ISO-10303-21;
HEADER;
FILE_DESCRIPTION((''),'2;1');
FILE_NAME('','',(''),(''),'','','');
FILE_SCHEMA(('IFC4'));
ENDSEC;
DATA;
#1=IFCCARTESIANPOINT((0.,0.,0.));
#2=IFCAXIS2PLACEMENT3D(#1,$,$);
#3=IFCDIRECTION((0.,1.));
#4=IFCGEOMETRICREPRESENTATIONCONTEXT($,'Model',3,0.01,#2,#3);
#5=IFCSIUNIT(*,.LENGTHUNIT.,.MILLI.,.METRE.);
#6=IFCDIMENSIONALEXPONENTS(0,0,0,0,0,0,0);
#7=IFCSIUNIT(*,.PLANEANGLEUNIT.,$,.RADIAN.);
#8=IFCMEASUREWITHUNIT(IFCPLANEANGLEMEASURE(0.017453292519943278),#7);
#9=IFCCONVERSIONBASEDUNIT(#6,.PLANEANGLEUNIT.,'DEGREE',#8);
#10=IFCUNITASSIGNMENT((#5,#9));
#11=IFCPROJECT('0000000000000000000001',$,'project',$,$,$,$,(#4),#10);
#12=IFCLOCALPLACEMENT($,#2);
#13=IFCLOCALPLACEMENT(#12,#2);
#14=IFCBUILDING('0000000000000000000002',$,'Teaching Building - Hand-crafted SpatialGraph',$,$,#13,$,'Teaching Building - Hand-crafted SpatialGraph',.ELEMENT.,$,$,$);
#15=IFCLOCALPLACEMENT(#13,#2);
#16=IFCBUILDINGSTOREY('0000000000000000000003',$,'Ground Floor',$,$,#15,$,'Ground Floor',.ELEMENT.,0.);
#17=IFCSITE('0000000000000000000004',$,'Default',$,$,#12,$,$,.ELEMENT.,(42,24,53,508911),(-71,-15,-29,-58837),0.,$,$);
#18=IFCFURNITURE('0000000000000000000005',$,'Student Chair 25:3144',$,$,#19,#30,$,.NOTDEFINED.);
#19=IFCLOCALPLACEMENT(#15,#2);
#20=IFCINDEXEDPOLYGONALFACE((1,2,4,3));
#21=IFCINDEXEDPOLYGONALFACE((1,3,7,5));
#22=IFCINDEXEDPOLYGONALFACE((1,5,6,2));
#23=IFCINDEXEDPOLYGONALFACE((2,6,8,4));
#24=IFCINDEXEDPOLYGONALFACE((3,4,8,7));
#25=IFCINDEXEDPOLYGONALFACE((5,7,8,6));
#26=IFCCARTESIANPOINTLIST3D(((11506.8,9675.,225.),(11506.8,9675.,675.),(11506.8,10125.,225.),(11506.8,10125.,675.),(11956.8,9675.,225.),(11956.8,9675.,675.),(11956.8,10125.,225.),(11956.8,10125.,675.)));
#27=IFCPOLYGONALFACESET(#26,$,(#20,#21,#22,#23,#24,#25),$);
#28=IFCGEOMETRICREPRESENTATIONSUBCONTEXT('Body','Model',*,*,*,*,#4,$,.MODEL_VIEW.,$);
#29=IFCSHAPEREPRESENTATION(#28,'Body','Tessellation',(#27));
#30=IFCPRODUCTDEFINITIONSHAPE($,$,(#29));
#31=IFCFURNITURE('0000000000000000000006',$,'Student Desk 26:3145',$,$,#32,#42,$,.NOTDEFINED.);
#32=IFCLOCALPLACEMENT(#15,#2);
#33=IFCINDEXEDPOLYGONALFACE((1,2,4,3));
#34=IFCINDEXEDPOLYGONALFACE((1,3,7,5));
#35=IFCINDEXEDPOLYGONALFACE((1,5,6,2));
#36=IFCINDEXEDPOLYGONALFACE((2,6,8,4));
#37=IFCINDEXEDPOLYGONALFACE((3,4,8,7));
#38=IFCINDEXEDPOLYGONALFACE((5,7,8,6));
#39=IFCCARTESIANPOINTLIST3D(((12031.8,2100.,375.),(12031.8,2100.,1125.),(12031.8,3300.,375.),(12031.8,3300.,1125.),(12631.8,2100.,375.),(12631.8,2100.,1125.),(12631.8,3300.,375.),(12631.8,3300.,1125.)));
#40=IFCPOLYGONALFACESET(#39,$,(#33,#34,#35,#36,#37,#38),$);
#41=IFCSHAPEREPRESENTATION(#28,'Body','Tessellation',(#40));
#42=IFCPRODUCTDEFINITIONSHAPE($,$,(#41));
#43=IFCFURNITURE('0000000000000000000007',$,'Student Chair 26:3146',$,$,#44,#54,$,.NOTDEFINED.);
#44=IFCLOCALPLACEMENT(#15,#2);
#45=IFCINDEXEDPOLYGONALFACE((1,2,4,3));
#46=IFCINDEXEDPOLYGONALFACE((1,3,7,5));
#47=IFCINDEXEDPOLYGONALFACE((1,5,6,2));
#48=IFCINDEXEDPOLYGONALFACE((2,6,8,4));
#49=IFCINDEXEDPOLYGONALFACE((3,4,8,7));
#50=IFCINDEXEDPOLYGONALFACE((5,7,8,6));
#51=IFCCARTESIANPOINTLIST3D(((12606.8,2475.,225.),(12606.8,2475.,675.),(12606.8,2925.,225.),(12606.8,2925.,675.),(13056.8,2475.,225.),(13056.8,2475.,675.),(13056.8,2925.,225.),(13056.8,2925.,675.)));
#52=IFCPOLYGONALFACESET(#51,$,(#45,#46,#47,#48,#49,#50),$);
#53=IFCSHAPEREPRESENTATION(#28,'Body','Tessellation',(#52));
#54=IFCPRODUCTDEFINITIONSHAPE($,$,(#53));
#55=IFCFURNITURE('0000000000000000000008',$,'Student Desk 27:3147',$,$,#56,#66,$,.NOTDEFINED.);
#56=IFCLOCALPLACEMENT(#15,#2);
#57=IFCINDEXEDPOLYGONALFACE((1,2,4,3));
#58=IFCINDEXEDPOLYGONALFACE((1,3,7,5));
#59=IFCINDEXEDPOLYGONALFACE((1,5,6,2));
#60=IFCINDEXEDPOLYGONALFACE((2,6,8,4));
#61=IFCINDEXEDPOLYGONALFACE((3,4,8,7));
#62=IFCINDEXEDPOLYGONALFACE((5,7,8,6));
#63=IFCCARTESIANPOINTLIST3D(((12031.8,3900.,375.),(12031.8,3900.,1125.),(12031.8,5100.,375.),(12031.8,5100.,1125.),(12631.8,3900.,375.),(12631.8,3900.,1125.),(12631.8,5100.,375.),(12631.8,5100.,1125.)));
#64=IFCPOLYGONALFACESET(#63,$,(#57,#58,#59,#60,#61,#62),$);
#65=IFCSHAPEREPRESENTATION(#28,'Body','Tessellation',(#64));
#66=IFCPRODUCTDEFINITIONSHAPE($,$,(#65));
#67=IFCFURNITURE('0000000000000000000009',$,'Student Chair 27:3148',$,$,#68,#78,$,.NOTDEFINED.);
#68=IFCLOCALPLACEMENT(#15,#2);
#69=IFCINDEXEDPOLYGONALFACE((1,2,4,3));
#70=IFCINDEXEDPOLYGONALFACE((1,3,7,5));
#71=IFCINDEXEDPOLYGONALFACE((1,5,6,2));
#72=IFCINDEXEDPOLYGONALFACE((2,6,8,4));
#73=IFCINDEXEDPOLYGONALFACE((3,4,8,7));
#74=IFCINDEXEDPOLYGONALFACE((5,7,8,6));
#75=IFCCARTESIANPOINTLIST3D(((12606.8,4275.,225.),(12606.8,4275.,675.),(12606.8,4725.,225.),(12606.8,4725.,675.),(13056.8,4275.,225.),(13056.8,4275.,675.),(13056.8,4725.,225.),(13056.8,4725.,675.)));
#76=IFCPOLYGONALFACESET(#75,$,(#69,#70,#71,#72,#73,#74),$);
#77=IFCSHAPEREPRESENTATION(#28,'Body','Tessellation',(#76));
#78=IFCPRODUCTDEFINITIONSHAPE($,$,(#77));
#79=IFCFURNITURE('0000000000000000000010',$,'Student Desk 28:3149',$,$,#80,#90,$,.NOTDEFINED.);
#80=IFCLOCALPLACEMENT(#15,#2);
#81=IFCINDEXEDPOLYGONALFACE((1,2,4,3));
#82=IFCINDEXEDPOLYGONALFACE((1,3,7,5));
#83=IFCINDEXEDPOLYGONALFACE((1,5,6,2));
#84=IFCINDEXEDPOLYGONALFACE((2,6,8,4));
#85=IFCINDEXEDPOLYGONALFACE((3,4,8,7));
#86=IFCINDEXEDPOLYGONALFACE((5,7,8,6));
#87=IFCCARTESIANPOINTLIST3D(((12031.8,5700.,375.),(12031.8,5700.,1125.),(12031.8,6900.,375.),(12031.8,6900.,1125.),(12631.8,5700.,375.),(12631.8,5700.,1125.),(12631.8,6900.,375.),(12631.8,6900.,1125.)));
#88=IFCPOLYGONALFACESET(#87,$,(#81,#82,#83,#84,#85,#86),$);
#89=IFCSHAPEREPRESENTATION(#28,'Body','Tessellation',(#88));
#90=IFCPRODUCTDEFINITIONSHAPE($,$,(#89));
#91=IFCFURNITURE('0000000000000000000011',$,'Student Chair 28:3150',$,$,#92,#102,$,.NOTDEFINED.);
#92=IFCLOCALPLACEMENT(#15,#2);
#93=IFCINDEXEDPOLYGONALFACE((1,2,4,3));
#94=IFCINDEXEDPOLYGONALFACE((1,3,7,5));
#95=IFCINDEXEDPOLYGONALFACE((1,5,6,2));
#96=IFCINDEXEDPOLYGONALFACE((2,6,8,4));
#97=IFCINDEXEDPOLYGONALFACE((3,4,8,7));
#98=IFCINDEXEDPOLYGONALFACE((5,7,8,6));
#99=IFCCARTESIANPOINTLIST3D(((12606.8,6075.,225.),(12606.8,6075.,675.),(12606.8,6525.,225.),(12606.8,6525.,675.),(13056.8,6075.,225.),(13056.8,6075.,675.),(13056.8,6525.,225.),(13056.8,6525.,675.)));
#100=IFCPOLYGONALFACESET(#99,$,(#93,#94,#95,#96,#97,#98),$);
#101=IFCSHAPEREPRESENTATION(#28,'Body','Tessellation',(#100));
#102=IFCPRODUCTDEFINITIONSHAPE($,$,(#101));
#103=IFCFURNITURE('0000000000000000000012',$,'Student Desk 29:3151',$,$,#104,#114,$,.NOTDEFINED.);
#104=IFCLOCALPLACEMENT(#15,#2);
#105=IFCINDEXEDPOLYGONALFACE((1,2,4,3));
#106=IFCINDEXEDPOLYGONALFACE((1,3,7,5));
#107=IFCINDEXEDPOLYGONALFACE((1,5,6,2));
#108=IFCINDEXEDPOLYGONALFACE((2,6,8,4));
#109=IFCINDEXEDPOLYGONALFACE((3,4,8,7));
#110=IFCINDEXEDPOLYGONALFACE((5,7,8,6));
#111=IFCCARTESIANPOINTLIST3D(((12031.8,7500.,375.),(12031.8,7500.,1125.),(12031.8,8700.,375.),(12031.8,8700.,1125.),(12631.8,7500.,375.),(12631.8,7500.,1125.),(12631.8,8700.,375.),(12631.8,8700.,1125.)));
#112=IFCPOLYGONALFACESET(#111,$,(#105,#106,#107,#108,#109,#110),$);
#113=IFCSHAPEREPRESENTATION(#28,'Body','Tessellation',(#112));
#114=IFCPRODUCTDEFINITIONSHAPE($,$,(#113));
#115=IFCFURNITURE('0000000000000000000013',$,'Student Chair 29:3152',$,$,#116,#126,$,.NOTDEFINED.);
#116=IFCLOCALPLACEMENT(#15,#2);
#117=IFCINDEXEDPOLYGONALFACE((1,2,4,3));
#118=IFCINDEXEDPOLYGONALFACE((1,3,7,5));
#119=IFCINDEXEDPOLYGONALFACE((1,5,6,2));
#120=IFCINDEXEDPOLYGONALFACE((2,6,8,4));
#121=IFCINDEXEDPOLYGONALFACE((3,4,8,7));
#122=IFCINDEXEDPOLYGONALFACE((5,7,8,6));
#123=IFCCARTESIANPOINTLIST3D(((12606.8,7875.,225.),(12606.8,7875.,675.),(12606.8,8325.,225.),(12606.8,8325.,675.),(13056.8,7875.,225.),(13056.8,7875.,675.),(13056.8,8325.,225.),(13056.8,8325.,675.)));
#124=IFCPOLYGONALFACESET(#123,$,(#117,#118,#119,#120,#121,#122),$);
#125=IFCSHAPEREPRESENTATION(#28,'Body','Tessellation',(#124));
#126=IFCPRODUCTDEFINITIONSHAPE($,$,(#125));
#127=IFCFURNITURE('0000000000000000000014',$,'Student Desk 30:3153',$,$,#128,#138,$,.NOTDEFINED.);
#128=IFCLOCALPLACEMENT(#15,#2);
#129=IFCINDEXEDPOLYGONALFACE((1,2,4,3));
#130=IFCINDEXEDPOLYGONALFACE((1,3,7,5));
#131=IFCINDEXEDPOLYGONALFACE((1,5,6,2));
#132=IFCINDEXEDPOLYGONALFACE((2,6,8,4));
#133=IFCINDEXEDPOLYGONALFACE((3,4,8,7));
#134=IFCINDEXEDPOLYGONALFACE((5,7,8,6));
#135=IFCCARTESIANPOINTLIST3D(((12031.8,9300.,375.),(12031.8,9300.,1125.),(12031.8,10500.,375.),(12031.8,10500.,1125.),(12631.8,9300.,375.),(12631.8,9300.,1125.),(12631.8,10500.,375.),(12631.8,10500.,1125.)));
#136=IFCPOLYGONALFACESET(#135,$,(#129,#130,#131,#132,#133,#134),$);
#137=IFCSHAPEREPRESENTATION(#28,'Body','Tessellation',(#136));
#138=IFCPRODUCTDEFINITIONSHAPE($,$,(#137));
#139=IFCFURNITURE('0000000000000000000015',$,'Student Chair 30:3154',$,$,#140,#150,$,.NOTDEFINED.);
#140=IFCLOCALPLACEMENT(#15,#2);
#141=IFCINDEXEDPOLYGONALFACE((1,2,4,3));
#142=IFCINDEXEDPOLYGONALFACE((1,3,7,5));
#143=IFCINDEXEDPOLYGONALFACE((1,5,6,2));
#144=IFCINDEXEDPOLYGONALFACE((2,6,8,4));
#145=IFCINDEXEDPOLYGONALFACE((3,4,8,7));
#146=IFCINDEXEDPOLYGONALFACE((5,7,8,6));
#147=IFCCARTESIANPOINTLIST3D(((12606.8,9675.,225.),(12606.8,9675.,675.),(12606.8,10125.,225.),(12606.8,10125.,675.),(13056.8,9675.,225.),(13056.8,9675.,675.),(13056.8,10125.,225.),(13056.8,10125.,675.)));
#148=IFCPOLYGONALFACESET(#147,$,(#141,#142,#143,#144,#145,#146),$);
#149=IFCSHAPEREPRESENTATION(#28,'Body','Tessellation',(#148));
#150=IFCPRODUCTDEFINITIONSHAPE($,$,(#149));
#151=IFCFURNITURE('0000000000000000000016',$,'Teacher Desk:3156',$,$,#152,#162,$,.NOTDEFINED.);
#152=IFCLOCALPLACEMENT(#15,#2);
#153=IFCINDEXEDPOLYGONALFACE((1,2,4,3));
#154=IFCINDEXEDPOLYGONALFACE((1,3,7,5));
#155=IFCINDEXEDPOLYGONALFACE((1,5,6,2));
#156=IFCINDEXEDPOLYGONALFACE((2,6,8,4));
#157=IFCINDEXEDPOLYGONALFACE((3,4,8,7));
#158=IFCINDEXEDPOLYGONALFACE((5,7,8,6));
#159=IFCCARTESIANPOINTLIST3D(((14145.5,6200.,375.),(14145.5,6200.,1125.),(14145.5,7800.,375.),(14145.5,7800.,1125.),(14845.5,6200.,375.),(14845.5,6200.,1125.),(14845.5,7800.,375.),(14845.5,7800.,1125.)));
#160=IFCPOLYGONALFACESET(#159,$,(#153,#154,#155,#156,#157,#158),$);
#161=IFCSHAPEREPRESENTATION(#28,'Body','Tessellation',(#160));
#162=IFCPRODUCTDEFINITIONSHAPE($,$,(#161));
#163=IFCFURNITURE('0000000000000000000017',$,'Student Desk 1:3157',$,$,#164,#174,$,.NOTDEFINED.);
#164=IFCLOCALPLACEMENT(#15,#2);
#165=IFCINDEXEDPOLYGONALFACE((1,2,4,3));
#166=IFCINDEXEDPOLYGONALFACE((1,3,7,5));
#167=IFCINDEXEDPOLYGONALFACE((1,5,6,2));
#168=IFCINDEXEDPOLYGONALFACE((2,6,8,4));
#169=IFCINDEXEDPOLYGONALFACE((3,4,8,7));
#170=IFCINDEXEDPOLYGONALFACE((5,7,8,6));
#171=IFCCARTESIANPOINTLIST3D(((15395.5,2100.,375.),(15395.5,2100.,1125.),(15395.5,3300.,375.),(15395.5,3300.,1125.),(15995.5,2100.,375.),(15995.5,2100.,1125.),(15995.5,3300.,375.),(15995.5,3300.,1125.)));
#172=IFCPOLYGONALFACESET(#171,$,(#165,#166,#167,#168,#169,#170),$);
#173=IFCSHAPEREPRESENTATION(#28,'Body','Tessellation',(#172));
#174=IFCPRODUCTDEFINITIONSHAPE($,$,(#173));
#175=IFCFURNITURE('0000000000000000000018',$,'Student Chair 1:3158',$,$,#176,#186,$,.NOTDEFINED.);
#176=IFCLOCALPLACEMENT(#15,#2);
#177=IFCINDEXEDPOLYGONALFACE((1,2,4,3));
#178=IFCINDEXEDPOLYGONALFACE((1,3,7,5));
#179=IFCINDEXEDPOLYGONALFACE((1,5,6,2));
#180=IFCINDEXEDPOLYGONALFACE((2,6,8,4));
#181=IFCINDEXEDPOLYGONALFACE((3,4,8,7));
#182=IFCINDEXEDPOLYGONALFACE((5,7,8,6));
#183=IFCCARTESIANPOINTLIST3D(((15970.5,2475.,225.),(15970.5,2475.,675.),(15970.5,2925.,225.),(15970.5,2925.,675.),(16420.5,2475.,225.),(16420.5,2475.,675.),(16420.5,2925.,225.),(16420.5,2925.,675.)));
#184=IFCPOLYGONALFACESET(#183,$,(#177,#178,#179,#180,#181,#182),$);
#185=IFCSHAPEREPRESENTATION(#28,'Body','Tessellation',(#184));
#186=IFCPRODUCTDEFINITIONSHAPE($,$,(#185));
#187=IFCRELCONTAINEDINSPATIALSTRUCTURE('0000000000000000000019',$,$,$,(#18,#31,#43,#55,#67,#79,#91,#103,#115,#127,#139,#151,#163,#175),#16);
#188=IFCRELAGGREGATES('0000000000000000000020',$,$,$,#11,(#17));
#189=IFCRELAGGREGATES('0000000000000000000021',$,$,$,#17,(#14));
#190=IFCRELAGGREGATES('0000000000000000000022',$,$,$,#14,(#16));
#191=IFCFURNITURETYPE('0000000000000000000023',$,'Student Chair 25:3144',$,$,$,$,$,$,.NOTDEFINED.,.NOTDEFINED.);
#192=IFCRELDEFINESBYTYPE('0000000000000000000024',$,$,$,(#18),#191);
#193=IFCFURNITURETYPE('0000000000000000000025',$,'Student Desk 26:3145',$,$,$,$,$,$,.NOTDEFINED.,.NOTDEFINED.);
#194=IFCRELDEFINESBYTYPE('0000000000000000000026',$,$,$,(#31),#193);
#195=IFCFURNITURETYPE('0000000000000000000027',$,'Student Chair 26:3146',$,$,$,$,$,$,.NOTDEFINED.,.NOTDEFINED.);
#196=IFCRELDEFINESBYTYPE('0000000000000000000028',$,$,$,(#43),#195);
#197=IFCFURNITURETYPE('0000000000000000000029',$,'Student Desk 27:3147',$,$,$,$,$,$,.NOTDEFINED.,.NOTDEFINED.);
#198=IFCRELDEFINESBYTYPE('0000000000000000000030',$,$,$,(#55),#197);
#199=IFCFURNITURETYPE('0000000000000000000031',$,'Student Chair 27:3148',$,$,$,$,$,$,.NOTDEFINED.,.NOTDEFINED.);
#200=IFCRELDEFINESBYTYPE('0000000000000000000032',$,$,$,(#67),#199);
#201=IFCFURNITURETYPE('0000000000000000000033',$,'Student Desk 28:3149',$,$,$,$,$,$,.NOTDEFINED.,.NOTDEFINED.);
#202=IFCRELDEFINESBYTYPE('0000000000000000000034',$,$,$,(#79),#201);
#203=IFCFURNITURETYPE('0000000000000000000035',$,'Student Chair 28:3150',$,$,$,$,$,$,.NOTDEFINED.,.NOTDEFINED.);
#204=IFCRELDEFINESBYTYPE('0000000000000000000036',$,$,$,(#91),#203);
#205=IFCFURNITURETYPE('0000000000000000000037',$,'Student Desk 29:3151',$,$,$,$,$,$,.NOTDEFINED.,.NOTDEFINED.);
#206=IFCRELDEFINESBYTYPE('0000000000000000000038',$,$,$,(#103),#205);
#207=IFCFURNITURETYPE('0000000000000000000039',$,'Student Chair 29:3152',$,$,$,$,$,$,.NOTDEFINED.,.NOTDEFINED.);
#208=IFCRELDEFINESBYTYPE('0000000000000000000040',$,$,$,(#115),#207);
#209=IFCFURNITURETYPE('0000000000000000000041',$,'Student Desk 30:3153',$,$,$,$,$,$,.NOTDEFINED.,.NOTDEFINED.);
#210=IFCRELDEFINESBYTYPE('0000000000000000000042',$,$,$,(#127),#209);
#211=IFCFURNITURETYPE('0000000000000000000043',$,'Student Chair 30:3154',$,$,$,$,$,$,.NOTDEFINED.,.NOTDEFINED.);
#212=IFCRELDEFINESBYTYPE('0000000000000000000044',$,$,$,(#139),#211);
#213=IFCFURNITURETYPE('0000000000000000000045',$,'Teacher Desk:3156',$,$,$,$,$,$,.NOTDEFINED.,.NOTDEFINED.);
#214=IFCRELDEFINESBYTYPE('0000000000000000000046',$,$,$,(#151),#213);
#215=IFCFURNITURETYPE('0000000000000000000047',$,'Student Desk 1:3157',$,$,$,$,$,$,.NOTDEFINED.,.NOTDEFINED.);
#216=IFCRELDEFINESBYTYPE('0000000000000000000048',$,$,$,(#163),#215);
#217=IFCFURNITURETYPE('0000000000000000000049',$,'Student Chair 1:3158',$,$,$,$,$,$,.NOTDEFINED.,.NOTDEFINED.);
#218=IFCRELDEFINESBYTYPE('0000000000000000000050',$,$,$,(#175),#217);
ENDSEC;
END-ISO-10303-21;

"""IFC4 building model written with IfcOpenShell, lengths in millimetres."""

from ifc_helpers import new_model, entity, si_unit, converted_unit, direction, frame, frame_2d, origin, origin_2d_with_axis, place, context, subcontext, project, spatial, rectangle, extrude, type_object, element, save


model = new_model("IFC4")

# Units and contexts
model_context = context("Model", 3, precision=0.01, world=origin(), true_north=direction((0.0, 1.0)))
body_context = subcontext(model_context, "Body", "Model", "MODEL_VIEW")
ifc_project = project(units=[si_unit("LENGTHUNIT", "METRE", prefix="MILLI"), converted_unit("PLANEANGLEUNIT", "DEGREE", entity("IfcPlaneAngleMeasure", 0.017453292519943278), si_unit("PLANEANGLEUNIT", "RADIAN"), dimensions=[0, 0, 0, 0, 0, 0, 0])], contexts=[model_context])

# Site, building, storey
site_placement = place(None, origin())
site = spatial("IfcSite", under=ifc_project, at=site_placement, Name="Default", CompositionType="ELEMENT", RefLatitude=(42, 24, 53, 508911), RefLongitude=(-71, -15, -29, -58837), RefElevation=0.0)
building_placement = place(site_placement, origin())
building = spatial("IfcBuilding", under=site, at=building_placement, Name="Teaching Building - Hand-crafted SpatialGraph", LongName="Teaching Building - Hand-crafted SpatialGraph", CompositionType="ELEMENT")
storey_placement = place(building_placement, origin())
storey = spatial("IfcBuildingStorey", under=building, at=storey_placement, Name="Ground Floor", LongName="Ground Floor", CompositionType="ELEMENT", Elevation=0.0)

# Furniture
furniture_type_1 = type_object("IfcFurnitureType", Name="Student Chair 25:3144", PredefinedType="NOTDEFINED")
furniture_1_placement = place(storey_placement, origin())
element("IfcFurniture", 1, at=furniture_1_placement, inside=storey, type_object=furniture_type_1, Name="Student Chair 25:3144", PredefinedType="NOTDEFINED", context=body_context, shape_type="SweptSolid", body=[
    extrude(rectangle(XDim=450.0, YDim=450.0, at=frame_2d((0.0, 0.0), x_axis=(1.0, 0.0))), frame((11731.8, 9900.0, 225.0)), (0.0, 0.0, 1.0), 450.0),
])
furniture_type_2 = type_object("IfcFurnitureType", Name="Student Desk 26:3145", PredefinedType="NOTDEFINED")
furniture_2_placement = place(storey_placement, origin())
element("IfcFurniture", 2, at=furniture_2_placement, inside=storey, type_object=furniture_type_2, Name="Student Desk 26:3145", PredefinedType="NOTDEFINED", context=body_context, shape_type="SweptSolid", body=[
    extrude(rectangle(XDim=1200.0, YDim=600.0, at=origin_2d_with_axis()), frame((12331.8, 2700.0, 375.0), z_axis=(0.0, 0.0, 1.0), x_axis=(0.0, 1.0, 0.0)), (0.0, 0.0, 1.0), 750.0),
])
furniture_type_3 = type_object("IfcFurnitureType", Name="Student Chair 26:3146", PredefinedType="NOTDEFINED")
furniture_3_placement = place(storey_placement, origin())
element("IfcFurniture", 3, at=furniture_3_placement, inside=storey, type_object=furniture_type_3, Name="Student Chair 26:3146", PredefinedType="NOTDEFINED", context=body_context, shape_type="SweptSolid", body=[
    extrude(rectangle(XDim=450.0, YDim=450.0, at=origin_2d_with_axis()), frame((12831.8, 2700.0, 225.0)), (0.0, 0.0, 1.0), 450.0),
])
furniture_type_4 = type_object("IfcFurnitureType", Name="Student Desk 27:3147", PredefinedType="NOTDEFINED")
furniture_4_placement = place(storey_placement, origin())
element("IfcFurniture", 4, at=furniture_4_placement, inside=storey, type_object=furniture_type_4, Name="Student Desk 27:3147", PredefinedType="NOTDEFINED", context=body_context, shape_type="SweptSolid", body=[
    extrude(rectangle(XDim=1200.0, YDim=600.0, at=frame_2d((0.0, 0.0), x_axis=(1.0, 0.0))), frame((12331.8, 4500.0, 375.0), z_axis=(0.0, 0.0, 1.0), x_axis=(0.0, 1.0, 0.0)), (0.0, 0.0, 1.0), 750.0),
])
furniture_type_5 = type_object("IfcFurnitureType", Name="Student Chair 27:3148", PredefinedType="NOTDEFINED")
furniture_5_placement = place(storey_placement, origin())
element("IfcFurniture", 5, at=furniture_5_placement, inside=storey, type_object=furniture_type_5, Name="Student Chair 27:3148", PredefinedType="NOTDEFINED", context=body_context, shape_type="SweptSolid", body=[
    extrude(rectangle(XDim=450.0, YDim=450.0, at=origin_2d_with_axis()), frame((12831.8, 4500.0, 225.0)), (0.0, 0.0, 1.0), 450.0),
])
furniture_type_6 = type_object("IfcFurnitureType", Name="Student Desk 28:3149", PredefinedType="NOTDEFINED")
furniture_6_placement = place(storey_placement, origin())
element("IfcFurniture", 6, at=furniture_6_placement, inside=storey, type_object=furniture_type_6, Name="Student Desk 28:3149", PredefinedType="NOTDEFINED", context=body_context, shape_type="SweptSolid", body=[
    extrude(rectangle(XDim=1200.0, YDim=600.0, at=origin_2d_with_axis()), frame((12331.8, 6300.0, 375.0), z_axis=(0.0, 0.0, 1.0), x_axis=(0.0, 1.0, 0.0)), (0.0, 0.0, 1.0), 750.0),
])
furniture_type_7 = type_object("IfcFurnitureType", Name="Student Chair 28:3150", PredefinedType="NOTDEFINED")
furniture_7_placement = place(storey_placement, origin())
element("IfcFurniture", 7, at=furniture_7_placement, inside=storey, type_object=furniture_type_7, Name="Student Chair 28:3150", PredefinedType="NOTDEFINED", context=body_context, shape_type="SweptSolid", body=[
    extrude(rectangle(XDim=450.0, YDim=450.0, at=origin_2d_with_axis()), frame((12831.8, 6300.0, 225.0)), (0.0, 0.0, 1.0), 450.0),
])
furniture_type_8 = type_object("IfcFurnitureType", Name="Student Desk 29:3151", PredefinedType="NOTDEFINED")
furniture_8_placement = place(storey_placement, origin())
element("IfcFurniture", 8, at=furniture_8_placement, inside=storey, type_object=furniture_type_8, Name="Student Desk 29:3151", PredefinedType="NOTDEFINED", context=body_context, shape_type="SweptSolid", body=[
    extrude(rectangle(XDim=1200.0, YDim=600.0, at=origin_2d_with_axis()), frame((12331.8, 8100.0, 375.0), z_axis=(0.0, 0.0, 1.0), x_axis=(0.0, 1.0, 0.0)), (0.0, 0.0, 1.0), 750.0),
])
furniture_type_9 = type_object("IfcFurnitureType", Name="Student Chair 29:3152", PredefinedType="NOTDEFINED")
furniture_9_placement = place(storey_placement, origin())
element("IfcFurniture", 9, at=furniture_9_placement, inside=storey, type_object=furniture_type_9, Name="Student Chair 29:3152", PredefinedType="NOTDEFINED", context=body_context, shape_type="SweptSolid", body=[
    extrude(rectangle(XDim=450.0, YDim=450.0, at=origin_2d_with_axis()), frame((12831.8, 8100.0, 225.0)), (0.0, 0.0, 1.0), 450.0),
])
furniture_type_10 = type_object("IfcFurnitureType", Name="Student Desk 30:3153", PredefinedType="NOTDEFINED")
furniture_10_placement = place(storey_placement, origin())
element("IfcFurniture", 10, at=furniture_10_placement, inside=storey, type_object=furniture_type_10, Name="Student Desk 30:3153", PredefinedType="NOTDEFINED", context=body_context, shape_type="SweptSolid", body=[
    extrude(rectangle(XDim=1200.0, YDim=600.0, at=origin_2d_with_axis()), frame((12331.8, 9900.0, 375.0), z_axis=(0.0, 0.0, 1.0), x_axis=(0.0, 1.0, 0.0)), (0.0, 0.0, 1.0), 750.0),
])
furniture_type_11 = type_object("IfcFurnitureType", Name="Student Chair 30:3154", PredefinedType="NOTDEFINED")
furniture_11_placement = place(storey_placement, origin())
element("IfcFurniture", 11, at=furniture_11_placement, inside=storey, type_object=furniture_type_11, Name="Student Chair 30:3154", PredefinedType="NOTDEFINED", context=body_context, shape_type="SweptSolid", body=[
    extrude(rectangle(XDim=450.0, YDim=450.0, at=frame_2d((0.0, 0.0), x_axis=(1.0, 0.0))), frame((12831.8, 9900.0, 225.0)), (0.0, 0.0, 1.0), 450.0),
])
furniture_type_12 = type_object("IfcFurnitureType", Name="Teacher Desk:3156", PredefinedType="NOTDEFINED")
furniture_12_placement = place(storey_placement, origin())
element("IfcFurniture", 12, at=furniture_12_placement, inside=storey, type_object=furniture_type_12, Name="Teacher Desk:3156", PredefinedType="NOTDEFINED", context=body_context, shape_type="SweptSolid", body=[
    extrude(rectangle(XDim=1600.0, YDim=700.0, at=origin_2d_with_axis()), frame((14495.5, 7000.0, 375.0), z_axis=(0.0, 0.0, 1.0), x_axis=(0.0, 1.0, 0.0)), (0.0, 0.0, 1.0), 750.0),
])
furniture_type_13 = type_object("IfcFurnitureType", Name="Student Desk 1:3157", PredefinedType="NOTDEFINED")
furniture_13_placement = place(storey_placement, origin())
element("IfcFurniture", 13, at=furniture_13_placement, inside=storey, type_object=furniture_type_13, Name="Student Desk 1:3157", PredefinedType="NOTDEFINED", context=body_context, shape_type="SweptSolid", body=[
    extrude(rectangle(XDim=1200.0, YDim=600.0, at=origin_2d_with_axis()), frame((15695.5, 2700.0, 375.0), z_axis=(0.0, 0.0, 1.0), x_axis=(0.0, 1.0, 0.0)), (0.0, 0.0, 1.0), 750.0),
])
furniture_type_14 = type_object("IfcFurnitureType", Name="Student Chair 1:3158", PredefinedType="NOTDEFINED")
furniture_14_placement = place(storey_placement, origin())
element("IfcFurniture", 14, at=furniture_14_placement, inside=storey, type_object=furniture_type_14, Name="Student Chair 1:3158", PredefinedType="NOTDEFINED", context=body_context, shape_type="SweptSolid", body=[
    extrude(rectangle(XDim=450.0, YDim=450.0, at=origin_2d_with_axis()), frame((16195.5, 2700.0, 225.0)), (0.0, 0.0, 1.0), 450.0),
])

save(model, "model.ifc")
